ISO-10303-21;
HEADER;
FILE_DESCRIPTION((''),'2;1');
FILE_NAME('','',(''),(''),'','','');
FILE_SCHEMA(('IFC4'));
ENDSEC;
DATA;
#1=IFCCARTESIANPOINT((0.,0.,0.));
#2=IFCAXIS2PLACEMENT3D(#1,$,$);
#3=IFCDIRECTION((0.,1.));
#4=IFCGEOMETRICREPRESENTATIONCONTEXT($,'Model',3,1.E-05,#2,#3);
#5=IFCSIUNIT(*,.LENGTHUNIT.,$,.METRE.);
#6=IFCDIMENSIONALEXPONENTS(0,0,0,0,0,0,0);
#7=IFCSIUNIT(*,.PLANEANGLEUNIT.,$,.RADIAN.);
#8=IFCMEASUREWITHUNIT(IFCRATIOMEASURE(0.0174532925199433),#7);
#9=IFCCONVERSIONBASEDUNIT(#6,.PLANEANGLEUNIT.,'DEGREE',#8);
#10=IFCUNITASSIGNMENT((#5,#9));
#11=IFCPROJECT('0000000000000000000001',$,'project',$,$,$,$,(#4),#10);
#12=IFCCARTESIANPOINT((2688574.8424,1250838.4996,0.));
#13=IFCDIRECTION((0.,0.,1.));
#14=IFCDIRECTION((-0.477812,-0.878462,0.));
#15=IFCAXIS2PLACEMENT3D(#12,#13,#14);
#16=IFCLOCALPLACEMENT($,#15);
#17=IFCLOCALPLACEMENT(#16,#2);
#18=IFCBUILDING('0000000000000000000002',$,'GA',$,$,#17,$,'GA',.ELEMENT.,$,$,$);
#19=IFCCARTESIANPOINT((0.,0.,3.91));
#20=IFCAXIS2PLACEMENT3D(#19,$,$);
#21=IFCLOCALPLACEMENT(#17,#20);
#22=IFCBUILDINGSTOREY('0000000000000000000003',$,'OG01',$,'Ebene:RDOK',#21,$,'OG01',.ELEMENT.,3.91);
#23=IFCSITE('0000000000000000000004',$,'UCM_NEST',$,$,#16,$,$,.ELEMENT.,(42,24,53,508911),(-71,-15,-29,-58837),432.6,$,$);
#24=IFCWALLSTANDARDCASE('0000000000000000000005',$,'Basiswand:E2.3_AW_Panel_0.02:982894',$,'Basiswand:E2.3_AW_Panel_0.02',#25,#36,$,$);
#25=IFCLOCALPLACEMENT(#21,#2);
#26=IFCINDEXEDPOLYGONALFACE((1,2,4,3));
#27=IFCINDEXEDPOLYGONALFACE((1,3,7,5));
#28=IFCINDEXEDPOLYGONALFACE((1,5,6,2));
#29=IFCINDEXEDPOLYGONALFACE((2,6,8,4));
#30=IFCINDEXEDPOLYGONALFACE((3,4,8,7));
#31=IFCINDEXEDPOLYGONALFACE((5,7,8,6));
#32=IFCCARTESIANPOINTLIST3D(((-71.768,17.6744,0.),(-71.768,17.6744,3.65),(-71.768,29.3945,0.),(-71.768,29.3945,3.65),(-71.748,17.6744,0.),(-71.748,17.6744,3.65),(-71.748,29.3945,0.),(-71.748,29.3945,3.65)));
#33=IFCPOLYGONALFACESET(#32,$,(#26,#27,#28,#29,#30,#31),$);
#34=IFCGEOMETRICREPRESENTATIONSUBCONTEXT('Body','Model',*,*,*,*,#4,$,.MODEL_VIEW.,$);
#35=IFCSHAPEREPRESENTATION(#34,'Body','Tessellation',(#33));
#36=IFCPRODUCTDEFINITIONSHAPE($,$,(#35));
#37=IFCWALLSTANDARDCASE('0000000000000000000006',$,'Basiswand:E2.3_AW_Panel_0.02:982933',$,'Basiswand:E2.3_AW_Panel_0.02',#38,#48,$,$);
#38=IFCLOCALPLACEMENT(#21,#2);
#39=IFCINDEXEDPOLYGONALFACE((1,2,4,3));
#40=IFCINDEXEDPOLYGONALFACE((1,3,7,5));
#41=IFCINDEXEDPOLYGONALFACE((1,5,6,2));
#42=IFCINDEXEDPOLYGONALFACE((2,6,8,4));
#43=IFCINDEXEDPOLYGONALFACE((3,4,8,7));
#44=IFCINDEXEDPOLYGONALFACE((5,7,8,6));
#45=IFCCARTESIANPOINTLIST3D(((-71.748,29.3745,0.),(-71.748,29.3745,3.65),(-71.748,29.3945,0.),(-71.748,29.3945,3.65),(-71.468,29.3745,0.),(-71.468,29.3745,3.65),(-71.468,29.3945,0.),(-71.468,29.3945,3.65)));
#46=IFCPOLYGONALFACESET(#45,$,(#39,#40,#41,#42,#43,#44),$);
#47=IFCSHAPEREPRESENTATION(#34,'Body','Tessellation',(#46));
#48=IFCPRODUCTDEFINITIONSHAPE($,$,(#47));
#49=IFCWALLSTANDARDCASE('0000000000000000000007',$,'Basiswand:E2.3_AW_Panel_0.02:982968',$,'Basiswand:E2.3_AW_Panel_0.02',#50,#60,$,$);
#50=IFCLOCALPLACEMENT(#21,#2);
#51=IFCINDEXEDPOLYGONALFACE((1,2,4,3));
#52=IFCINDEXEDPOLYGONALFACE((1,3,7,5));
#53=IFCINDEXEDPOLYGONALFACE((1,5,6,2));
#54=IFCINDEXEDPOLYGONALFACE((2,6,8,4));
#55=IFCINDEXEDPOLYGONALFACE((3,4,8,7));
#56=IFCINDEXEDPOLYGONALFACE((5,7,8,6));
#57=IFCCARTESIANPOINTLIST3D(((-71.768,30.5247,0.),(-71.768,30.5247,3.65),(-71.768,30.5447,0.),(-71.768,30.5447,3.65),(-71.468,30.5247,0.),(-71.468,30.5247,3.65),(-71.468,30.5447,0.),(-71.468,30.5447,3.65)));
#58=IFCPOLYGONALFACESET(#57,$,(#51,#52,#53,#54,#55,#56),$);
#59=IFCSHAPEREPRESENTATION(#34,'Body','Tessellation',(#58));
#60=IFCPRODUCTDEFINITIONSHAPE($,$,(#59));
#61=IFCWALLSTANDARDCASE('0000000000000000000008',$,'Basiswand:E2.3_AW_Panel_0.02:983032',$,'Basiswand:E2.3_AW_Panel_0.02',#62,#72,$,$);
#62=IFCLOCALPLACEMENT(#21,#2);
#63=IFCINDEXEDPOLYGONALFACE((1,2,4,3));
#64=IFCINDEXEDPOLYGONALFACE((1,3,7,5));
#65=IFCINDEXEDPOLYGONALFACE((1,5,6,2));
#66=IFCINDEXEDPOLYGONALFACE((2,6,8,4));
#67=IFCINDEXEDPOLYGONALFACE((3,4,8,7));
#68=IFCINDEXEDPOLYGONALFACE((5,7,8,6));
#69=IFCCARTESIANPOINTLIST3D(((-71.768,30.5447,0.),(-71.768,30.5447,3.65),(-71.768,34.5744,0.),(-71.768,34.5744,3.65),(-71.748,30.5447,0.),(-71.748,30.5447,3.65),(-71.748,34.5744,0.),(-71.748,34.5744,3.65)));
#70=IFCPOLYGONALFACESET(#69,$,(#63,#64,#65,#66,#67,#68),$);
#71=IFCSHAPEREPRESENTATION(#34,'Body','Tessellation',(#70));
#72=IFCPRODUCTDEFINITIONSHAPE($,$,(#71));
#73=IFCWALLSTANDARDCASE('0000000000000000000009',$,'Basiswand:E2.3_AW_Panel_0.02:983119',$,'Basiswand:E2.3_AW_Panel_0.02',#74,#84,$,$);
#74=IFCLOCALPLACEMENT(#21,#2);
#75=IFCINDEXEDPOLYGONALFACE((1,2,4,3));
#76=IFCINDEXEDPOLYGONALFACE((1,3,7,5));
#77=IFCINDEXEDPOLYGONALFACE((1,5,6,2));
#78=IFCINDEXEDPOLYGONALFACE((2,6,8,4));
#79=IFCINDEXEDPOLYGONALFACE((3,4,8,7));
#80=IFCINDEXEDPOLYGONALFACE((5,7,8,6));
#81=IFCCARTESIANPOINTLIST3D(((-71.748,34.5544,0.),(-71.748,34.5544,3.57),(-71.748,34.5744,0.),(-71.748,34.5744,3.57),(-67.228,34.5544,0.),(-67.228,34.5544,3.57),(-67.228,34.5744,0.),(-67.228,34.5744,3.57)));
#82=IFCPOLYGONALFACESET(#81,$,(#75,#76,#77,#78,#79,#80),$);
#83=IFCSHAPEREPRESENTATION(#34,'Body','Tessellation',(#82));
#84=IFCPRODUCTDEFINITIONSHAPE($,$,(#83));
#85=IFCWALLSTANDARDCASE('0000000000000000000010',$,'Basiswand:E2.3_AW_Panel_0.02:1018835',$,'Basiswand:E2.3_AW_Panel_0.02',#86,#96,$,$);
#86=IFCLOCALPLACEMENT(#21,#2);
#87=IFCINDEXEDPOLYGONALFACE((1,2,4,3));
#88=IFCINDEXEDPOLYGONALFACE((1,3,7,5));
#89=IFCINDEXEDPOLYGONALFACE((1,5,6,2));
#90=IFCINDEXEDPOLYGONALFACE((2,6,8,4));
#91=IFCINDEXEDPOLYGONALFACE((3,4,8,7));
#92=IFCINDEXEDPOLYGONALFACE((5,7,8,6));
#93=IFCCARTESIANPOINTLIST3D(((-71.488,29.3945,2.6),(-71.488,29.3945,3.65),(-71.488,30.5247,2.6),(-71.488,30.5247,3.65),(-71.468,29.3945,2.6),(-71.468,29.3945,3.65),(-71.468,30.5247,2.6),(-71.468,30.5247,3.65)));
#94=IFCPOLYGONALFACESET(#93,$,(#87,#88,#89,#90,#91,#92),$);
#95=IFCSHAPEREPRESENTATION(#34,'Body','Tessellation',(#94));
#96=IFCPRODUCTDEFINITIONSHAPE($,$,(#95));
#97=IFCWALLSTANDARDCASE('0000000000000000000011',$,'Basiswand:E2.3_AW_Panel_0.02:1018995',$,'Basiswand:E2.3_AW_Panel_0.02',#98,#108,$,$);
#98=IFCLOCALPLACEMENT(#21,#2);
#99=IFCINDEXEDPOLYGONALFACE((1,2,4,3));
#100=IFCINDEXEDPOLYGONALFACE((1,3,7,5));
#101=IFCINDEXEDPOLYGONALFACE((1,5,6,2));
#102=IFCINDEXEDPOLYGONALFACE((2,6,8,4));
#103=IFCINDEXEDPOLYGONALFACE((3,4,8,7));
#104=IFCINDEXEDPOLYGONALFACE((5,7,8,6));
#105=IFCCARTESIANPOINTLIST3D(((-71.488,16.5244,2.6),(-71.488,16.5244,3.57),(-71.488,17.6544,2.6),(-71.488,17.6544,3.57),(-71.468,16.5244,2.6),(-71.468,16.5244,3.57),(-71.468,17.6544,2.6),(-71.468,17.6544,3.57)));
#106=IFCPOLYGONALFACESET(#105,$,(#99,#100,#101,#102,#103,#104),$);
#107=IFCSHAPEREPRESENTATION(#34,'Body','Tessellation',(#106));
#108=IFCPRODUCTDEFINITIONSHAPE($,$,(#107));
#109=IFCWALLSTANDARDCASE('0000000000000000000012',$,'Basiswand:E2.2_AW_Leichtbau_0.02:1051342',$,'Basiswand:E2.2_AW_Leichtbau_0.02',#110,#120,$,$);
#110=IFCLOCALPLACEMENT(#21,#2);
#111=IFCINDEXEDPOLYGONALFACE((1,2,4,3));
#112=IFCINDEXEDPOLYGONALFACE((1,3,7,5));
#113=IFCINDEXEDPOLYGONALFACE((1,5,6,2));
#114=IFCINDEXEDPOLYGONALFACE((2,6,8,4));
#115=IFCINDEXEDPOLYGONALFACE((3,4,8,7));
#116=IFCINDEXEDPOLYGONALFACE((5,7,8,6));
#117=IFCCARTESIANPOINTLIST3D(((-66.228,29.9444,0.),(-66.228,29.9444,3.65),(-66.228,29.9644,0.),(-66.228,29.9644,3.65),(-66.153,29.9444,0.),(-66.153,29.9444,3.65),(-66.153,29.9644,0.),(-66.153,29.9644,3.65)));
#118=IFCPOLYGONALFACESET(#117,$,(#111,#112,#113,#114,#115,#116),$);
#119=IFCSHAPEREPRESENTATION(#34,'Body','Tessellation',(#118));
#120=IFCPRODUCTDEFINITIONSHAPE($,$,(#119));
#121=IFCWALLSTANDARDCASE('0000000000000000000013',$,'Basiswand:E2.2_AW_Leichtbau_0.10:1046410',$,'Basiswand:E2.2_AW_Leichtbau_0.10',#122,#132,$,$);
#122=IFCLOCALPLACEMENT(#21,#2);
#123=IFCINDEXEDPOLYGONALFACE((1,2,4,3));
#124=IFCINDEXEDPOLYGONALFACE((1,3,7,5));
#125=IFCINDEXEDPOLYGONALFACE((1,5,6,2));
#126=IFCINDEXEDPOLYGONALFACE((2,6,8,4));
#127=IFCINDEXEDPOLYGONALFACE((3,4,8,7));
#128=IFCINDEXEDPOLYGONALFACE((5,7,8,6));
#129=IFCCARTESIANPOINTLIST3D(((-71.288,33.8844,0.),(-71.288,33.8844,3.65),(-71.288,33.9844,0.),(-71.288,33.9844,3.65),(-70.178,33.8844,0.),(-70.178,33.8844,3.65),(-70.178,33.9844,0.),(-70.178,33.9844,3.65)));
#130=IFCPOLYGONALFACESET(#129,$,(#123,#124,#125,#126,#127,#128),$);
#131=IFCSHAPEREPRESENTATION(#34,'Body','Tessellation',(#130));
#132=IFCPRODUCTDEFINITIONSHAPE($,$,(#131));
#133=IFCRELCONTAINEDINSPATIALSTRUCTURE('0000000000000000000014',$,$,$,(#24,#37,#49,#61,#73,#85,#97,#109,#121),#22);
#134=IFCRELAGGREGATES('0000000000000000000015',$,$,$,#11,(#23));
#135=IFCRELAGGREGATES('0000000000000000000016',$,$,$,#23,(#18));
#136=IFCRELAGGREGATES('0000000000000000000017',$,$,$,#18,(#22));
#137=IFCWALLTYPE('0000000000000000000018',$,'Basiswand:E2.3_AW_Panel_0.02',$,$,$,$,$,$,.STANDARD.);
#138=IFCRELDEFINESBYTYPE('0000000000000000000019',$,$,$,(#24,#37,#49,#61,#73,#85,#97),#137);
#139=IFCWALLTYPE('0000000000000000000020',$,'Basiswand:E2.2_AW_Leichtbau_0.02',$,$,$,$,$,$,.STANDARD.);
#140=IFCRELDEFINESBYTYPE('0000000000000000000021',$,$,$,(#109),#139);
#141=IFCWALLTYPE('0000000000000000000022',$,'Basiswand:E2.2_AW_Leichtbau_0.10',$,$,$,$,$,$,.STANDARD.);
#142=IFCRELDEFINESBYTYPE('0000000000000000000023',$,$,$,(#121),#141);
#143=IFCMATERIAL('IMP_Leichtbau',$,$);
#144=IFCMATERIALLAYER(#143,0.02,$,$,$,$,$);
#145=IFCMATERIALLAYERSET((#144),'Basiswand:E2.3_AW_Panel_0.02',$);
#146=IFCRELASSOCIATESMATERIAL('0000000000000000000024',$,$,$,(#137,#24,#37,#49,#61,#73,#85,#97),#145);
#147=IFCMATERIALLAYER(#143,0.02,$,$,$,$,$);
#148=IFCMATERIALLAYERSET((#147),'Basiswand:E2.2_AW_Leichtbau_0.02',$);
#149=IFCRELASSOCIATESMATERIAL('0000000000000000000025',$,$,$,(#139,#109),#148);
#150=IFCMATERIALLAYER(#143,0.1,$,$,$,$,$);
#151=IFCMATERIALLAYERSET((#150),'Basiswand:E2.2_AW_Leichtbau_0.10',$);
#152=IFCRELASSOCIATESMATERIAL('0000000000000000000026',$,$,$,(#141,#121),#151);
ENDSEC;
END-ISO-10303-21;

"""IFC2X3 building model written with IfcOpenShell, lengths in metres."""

from ifc_helpers import new_model, entity, si_unit, converted_unit, direction, frame, frame_2d, origin, place, context, subcontext, project, spatial, polyline, rectangle, extrude, clip, bounded_halfspace, material, layer, layer_set, layer_usage, type_object, element, save


model = new_model("IFC2X3")

# Units and contexts
model_context = context("Model", 3, precision=1e-05, world=origin(), true_north=direction((0.0, 1.0)))
body_context = subcontext(model_context, "Body", "Model", "MODEL_VIEW")
ifc_project = project(units=[si_unit("LENGTHUNIT", "METRE"), converted_unit("PLANEANGLEUNIT", "DEGREE", entity("IfcRatioMeasure", 0.0174532925199433), si_unit("PLANEANGLEUNIT", "RADIAN"), dimensions=[0, 0, 0, 0, 0, 0, 0])], contexts=[model_context])

# Site, building, storey
site_placement = place(None, frame((2688574.8424, 1250838.4996, 0.0), z_axis=(0.0, 0.0, 1.0), x_axis=(-0.477812, -0.878462, 0.0)))
site = spatial("IfcSite", under=ifc_project, at=site_placement, Name="UCM_NEST", CompositionType="ELEMENT", RefLatitude=(42, 24, 53, 508911), RefLongitude=(-71, -15, -29, -58837), RefElevation=432.6)
building_placement = place(site_placement, origin())
building = spatial("IfcBuilding", under=site, at=building_placement, Name="GA", LongName="GA", CompositionType="ELEMENT")
storey_placement = place(building_placement, frame((0.0, 0.0, 3.91)))
storey = spatial("IfcBuildingStorey", under=building, at=storey_placement, Name="OG01", ObjectType="Ebene:RDOK", LongName="OG01", CompositionType="ELEMENT", Elevation=3.91)

# Shared definitions
ifc_material_1 = material(Name="IMP_Leichtbau")

# Walls
ifc_layer_1 = layer(ifc_material_1, 0.02)
ifc_layer_set_1 = layer_set([ifc_layer_1], Name="Basiswand:E2.3_AW_Panel_0.02")
wall_type_1 = type_object("IfcWallType", Name="Basiswand:E2.3_AW_Panel_0.02", PredefinedType="STANDARD", material=ifc_layer_set_1)
ifc_layer_usage_1 = layer_usage(ifc_layer_set_1, "AXIS2", "NEGATIVE", 0.01)
wall_1_placement = place(storey_placement, frame((-71.758, 17.6744, 0.0), z_axis=(0.0, 0.0, 1.0), x_axis=(0.0, 1.0, 0.0)))
element("IfcWallStandardCase", 1, at=wall_1_placement, inside=storey, type_object=wall_type_1, material=ifc_layer_usage_1, Name="Basiswand:E2.3_AW_Panel_0.02:982894", ObjectType="Basiswand:E2.3_AW_Panel_0.02", context=body_context, shape_type="SweptSolid", body=[
    extrude(rectangle(XDim=11.72, YDim=0.02, at=frame_2d((5.86, 0.0), x_axis=(-1.0, 0.0))), origin(), (0.0, 0.0, 1.0), 3.65),
])
ifc_layer_usage_2 = layer_usage(ifc_layer_set_1, "AXIS2", "NEGATIVE", 0.01)
wall_2_placement = place(storey_placement, frame((-71.748, 29.3845, 0.0)))
element("IfcWallStandardCase", 2, at=wall_2_placement, inside=storey, type_object=wall_type_1, material=ifc_layer_usage_2, Name="Basiswand:E2.3_AW_Panel_0.02:982933", ObjectType="Basiswand:E2.3_AW_Panel_0.02", context=body_context, shape_type="SweptSolid", body=[
    extrude(rectangle(XDim=0.28, YDim=0.02, at=frame_2d((0.14, 0.0), x_axis=(-1.0, 0.0))), origin(), (0.0, 0.0, 1.0), 3.65),
])
ifc_layer_usage_3 = layer_usage(ifc_layer_set_1, "AXIS2", "NEGATIVE", 0.01)
wall_3_placement = place(storey_placement, frame((-71.468, 30.5347, 0.0), z_axis=(0.0, 0.0, 1.0), x_axis=(-1.0, 0.0, 0.0)))
element("IfcWallStandardCase", 3, at=wall_3_placement, inside=storey, type_object=wall_type_1, material=ifc_layer_usage_3, Name="Basiswand:E2.3_AW_Panel_0.02:982968", ObjectType="Basiswand:E2.3_AW_Panel_0.02", context=body_context, shape_type="SweptSolid", body=[
    extrude(rectangle(XDim=0.3, YDim=0.02, at=frame_2d((0.15, 0.0), x_axis=(-1.0, 0.0))), origin(), (0.0, 0.0, 1.0), 3.65),
])
ifc_layer_usage_4 = layer_usage(ifc_layer_set_1, "AXIS2", "NEGATIVE", 0.01)
wall_4_placement = place(storey_placement, frame((-71.758, 30.5447, 0.0), z_axis=(0.0, 0.0, 1.0), x_axis=(0.0, 1.0, 0.0)))
element("IfcWallStandardCase", 4, at=wall_4_placement, inside=storey, type_object=wall_type_1, material=ifc_layer_usage_4, Name="Basiswand:E2.3_AW_Panel_0.02:983032", ObjectType="Basiswand:E2.3_AW_Panel_0.02", context=body_context, shape_type="SweptSolid", body=[
    extrude(rectangle(XDim=4.0298, YDim=0.02, at=frame_2d((2.0149, 0.0), x_axis=(-1.0, 0.0))), origin(), (0.0, 0.0, 1.0), 3.65),
])
ifc_layer_usage_5 = layer_usage(ifc_layer_set_1, "AXIS2", "NEGATIVE", 0.01)
wall_5_placement = place(storey_placement, frame((-71.748, 34.5644, 0.0)))
element("IfcWallStandardCase", 5, at=wall_5_placement, inside=storey, type_object=wall_type_1, material=ifc_layer_usage_5, Name="Basiswand:E2.3_AW_Panel_0.02:983119", ObjectType="Basiswand:E2.3_AW_Panel_0.02", context=body_context, shape_type="Clipping", body=[
    clip(extrude(rectangle(XDim=4.52, YDim=0.02, at=frame_2d((2.26, 0.0), x_axis=(-1.0, 0.0))), origin(), (0.0, 0.0, 1.0), 3.57), bounded_halfspace(frame((0.0, -0.01, 3.57), z_axis=(0.0, 0.0, -1.0), x_axis=(0.0, -1.0, 0.0)), True, frame((0.0, -0.01, 3.57), z_axis=(0.0, 0.0, -1.0), x_axis=(0.0, -1.0, 0.0)), polyline([(0.0, 0.0), (-0.02, 0.0), (-0.02, -4.52), (0.0, -4.52), (0.0, 0.0)]))),
])
ifc_layer_usage_6 = layer_usage(ifc_layer_set_1, "AXIS2", "NEGATIVE", 0.01)
wall_6_placement = place(storey_placement, frame((-71.478, 30.5247, 2.6), z_axis=(0.0, 0.0, 1.0), x_axis=(0.0, -1.0, 0.0)))
element("IfcWallStandardCase", 6, at=wall_6_placement, inside=storey, type_object=wall_type_1, material=ifc_layer_usage_6, Name="Basiswand:E2.3_AW_Panel_0.02:1018835", ObjectType="Basiswand:E2.3_AW_Panel_0.02", context=body_context, shape_type="SweptSolid", body=[
    extrude(rectangle(XDim=1.1302, YDim=0.02, at=frame_2d((0.5651, 0.0), x_axis=(-1.0, 0.0))), origin(), (0.0, 0.0, 1.0), 1.05),
])
ifc_layer_usage_7 = layer_usage(ifc_layer_set_1, "AXIS2", "NEGATIVE", 0.01)
wall_7_placement = place(storey_placement, frame((-71.478, 17.6544, 2.6), z_axis=(0.0, 0.0, 1.0), x_axis=(0.0, -1.0, 0.0)))
element("IfcWallStandardCase", 7, at=wall_7_placement, inside=storey, type_object=wall_type_1, material=ifc_layer_usage_7, Name="Basiswand:E2.3_AW_Panel_0.02:1018995", ObjectType="Basiswand:E2.3_AW_Panel_0.02", context=body_context, shape_type="Clipping", body=[
    clip(extrude(rectangle(XDim=1.13, YDim=0.02, at=frame_2d((0.565, 0.0), x_axis=(-1.0, 0.0))), origin(), (0.0, 0.0, 1.0), 0.97), bounded_halfspace(frame((0.0, -0.01, 0.97), z_axis=(0.0, 0.0, -1.0), x_axis=(1.0, 0.0, 0.0)), True, frame((0.0, -0.01, 0.97), z_axis=(0.0, 0.0, -1.0), x_axis=(1.0, 0.0, 0.0)), polyline([(0.0, 0.0), (0.0, -0.02), (1.13, -0.02), (1.13, 0.0), (0.0, 0.0)]))),
])
ifc_layer_2 = layer(ifc_material_1, 0.02)
ifc_layer_set_2 = layer_set([ifc_layer_2], Name="Basiswand:E2.2_AW_Leichtbau_0.02")
ifc_layer_usage_8 = layer_usage(ifc_layer_set_2, "AXIS2", "NEGATIVE", 0.01)
wall_type_2 = type_object("IfcWallType", Name="Basiswand:E2.2_AW_Leichtbau_0.02", PredefinedType="STANDARD", material=ifc_layer_set_2)
wall_8_placement = place(storey_placement, frame((-66.228, 29.9544, 0.0)))
element("IfcWallStandardCase", 8, at=wall_8_placement, inside=storey, type_object=wall_type_2, material=ifc_layer_usage_8, Name="Basiswand:E2.2_AW_Leichtbau_0.02:1051342", ObjectType="Basiswand:E2.2_AW_Leichtbau_0.02", context=body_context, shape_type="SweptSolid", body=[
    extrude(rectangle(XDim=0.075, YDim=0.02, at=frame_2d((0.0375, 0.0), x_axis=(-1.0, 0.0))), origin(), (0.0, 0.0, 1.0), 3.65),
])
ifc_layer_3 = layer(ifc_material_1, 0.1)
ifc_layer_set_3 = layer_set([ifc_layer_3], Name="Basiswand:E2.2_AW_Leichtbau_0.10")
ifc_layer_usage_9 = layer_usage(ifc_layer_set_3, "AXIS2", "NEGATIVE", 0.05)
wall_type_3 = type_object("IfcWallType", Name="Basiswand:E2.2_AW_Leichtbau_0.10", PredefinedType="STANDARD", material=ifc_layer_set_3)
wall_9_placement = place(storey_placement, frame((-70.178, 33.9344, 0.0), z_axis=(0.0, 0.0, 1.0), x_axis=(-1.0, 0.0, 0.0)))
element("IfcWallStandardCase", 9, at=wall_9_placement, inside=storey, type_object=wall_type_3, material=ifc_layer_usage_9, Name="Basiswand:E2.2_AW_Leichtbau_0.10:1046410", ObjectType="Basiswand:E2.2_AW_Leichtbau_0.10", context=body_context, shape_type="SweptSolid", body=[
    extrude(rectangle(XDim=1.11, YDim=0.1, at=frame_2d((0.555, 0.0), x_axis=(-1.0, 0.0))), origin(), (0.0, 0.0, 1.0), 3.65),
])

save(model, "model.ifc")
